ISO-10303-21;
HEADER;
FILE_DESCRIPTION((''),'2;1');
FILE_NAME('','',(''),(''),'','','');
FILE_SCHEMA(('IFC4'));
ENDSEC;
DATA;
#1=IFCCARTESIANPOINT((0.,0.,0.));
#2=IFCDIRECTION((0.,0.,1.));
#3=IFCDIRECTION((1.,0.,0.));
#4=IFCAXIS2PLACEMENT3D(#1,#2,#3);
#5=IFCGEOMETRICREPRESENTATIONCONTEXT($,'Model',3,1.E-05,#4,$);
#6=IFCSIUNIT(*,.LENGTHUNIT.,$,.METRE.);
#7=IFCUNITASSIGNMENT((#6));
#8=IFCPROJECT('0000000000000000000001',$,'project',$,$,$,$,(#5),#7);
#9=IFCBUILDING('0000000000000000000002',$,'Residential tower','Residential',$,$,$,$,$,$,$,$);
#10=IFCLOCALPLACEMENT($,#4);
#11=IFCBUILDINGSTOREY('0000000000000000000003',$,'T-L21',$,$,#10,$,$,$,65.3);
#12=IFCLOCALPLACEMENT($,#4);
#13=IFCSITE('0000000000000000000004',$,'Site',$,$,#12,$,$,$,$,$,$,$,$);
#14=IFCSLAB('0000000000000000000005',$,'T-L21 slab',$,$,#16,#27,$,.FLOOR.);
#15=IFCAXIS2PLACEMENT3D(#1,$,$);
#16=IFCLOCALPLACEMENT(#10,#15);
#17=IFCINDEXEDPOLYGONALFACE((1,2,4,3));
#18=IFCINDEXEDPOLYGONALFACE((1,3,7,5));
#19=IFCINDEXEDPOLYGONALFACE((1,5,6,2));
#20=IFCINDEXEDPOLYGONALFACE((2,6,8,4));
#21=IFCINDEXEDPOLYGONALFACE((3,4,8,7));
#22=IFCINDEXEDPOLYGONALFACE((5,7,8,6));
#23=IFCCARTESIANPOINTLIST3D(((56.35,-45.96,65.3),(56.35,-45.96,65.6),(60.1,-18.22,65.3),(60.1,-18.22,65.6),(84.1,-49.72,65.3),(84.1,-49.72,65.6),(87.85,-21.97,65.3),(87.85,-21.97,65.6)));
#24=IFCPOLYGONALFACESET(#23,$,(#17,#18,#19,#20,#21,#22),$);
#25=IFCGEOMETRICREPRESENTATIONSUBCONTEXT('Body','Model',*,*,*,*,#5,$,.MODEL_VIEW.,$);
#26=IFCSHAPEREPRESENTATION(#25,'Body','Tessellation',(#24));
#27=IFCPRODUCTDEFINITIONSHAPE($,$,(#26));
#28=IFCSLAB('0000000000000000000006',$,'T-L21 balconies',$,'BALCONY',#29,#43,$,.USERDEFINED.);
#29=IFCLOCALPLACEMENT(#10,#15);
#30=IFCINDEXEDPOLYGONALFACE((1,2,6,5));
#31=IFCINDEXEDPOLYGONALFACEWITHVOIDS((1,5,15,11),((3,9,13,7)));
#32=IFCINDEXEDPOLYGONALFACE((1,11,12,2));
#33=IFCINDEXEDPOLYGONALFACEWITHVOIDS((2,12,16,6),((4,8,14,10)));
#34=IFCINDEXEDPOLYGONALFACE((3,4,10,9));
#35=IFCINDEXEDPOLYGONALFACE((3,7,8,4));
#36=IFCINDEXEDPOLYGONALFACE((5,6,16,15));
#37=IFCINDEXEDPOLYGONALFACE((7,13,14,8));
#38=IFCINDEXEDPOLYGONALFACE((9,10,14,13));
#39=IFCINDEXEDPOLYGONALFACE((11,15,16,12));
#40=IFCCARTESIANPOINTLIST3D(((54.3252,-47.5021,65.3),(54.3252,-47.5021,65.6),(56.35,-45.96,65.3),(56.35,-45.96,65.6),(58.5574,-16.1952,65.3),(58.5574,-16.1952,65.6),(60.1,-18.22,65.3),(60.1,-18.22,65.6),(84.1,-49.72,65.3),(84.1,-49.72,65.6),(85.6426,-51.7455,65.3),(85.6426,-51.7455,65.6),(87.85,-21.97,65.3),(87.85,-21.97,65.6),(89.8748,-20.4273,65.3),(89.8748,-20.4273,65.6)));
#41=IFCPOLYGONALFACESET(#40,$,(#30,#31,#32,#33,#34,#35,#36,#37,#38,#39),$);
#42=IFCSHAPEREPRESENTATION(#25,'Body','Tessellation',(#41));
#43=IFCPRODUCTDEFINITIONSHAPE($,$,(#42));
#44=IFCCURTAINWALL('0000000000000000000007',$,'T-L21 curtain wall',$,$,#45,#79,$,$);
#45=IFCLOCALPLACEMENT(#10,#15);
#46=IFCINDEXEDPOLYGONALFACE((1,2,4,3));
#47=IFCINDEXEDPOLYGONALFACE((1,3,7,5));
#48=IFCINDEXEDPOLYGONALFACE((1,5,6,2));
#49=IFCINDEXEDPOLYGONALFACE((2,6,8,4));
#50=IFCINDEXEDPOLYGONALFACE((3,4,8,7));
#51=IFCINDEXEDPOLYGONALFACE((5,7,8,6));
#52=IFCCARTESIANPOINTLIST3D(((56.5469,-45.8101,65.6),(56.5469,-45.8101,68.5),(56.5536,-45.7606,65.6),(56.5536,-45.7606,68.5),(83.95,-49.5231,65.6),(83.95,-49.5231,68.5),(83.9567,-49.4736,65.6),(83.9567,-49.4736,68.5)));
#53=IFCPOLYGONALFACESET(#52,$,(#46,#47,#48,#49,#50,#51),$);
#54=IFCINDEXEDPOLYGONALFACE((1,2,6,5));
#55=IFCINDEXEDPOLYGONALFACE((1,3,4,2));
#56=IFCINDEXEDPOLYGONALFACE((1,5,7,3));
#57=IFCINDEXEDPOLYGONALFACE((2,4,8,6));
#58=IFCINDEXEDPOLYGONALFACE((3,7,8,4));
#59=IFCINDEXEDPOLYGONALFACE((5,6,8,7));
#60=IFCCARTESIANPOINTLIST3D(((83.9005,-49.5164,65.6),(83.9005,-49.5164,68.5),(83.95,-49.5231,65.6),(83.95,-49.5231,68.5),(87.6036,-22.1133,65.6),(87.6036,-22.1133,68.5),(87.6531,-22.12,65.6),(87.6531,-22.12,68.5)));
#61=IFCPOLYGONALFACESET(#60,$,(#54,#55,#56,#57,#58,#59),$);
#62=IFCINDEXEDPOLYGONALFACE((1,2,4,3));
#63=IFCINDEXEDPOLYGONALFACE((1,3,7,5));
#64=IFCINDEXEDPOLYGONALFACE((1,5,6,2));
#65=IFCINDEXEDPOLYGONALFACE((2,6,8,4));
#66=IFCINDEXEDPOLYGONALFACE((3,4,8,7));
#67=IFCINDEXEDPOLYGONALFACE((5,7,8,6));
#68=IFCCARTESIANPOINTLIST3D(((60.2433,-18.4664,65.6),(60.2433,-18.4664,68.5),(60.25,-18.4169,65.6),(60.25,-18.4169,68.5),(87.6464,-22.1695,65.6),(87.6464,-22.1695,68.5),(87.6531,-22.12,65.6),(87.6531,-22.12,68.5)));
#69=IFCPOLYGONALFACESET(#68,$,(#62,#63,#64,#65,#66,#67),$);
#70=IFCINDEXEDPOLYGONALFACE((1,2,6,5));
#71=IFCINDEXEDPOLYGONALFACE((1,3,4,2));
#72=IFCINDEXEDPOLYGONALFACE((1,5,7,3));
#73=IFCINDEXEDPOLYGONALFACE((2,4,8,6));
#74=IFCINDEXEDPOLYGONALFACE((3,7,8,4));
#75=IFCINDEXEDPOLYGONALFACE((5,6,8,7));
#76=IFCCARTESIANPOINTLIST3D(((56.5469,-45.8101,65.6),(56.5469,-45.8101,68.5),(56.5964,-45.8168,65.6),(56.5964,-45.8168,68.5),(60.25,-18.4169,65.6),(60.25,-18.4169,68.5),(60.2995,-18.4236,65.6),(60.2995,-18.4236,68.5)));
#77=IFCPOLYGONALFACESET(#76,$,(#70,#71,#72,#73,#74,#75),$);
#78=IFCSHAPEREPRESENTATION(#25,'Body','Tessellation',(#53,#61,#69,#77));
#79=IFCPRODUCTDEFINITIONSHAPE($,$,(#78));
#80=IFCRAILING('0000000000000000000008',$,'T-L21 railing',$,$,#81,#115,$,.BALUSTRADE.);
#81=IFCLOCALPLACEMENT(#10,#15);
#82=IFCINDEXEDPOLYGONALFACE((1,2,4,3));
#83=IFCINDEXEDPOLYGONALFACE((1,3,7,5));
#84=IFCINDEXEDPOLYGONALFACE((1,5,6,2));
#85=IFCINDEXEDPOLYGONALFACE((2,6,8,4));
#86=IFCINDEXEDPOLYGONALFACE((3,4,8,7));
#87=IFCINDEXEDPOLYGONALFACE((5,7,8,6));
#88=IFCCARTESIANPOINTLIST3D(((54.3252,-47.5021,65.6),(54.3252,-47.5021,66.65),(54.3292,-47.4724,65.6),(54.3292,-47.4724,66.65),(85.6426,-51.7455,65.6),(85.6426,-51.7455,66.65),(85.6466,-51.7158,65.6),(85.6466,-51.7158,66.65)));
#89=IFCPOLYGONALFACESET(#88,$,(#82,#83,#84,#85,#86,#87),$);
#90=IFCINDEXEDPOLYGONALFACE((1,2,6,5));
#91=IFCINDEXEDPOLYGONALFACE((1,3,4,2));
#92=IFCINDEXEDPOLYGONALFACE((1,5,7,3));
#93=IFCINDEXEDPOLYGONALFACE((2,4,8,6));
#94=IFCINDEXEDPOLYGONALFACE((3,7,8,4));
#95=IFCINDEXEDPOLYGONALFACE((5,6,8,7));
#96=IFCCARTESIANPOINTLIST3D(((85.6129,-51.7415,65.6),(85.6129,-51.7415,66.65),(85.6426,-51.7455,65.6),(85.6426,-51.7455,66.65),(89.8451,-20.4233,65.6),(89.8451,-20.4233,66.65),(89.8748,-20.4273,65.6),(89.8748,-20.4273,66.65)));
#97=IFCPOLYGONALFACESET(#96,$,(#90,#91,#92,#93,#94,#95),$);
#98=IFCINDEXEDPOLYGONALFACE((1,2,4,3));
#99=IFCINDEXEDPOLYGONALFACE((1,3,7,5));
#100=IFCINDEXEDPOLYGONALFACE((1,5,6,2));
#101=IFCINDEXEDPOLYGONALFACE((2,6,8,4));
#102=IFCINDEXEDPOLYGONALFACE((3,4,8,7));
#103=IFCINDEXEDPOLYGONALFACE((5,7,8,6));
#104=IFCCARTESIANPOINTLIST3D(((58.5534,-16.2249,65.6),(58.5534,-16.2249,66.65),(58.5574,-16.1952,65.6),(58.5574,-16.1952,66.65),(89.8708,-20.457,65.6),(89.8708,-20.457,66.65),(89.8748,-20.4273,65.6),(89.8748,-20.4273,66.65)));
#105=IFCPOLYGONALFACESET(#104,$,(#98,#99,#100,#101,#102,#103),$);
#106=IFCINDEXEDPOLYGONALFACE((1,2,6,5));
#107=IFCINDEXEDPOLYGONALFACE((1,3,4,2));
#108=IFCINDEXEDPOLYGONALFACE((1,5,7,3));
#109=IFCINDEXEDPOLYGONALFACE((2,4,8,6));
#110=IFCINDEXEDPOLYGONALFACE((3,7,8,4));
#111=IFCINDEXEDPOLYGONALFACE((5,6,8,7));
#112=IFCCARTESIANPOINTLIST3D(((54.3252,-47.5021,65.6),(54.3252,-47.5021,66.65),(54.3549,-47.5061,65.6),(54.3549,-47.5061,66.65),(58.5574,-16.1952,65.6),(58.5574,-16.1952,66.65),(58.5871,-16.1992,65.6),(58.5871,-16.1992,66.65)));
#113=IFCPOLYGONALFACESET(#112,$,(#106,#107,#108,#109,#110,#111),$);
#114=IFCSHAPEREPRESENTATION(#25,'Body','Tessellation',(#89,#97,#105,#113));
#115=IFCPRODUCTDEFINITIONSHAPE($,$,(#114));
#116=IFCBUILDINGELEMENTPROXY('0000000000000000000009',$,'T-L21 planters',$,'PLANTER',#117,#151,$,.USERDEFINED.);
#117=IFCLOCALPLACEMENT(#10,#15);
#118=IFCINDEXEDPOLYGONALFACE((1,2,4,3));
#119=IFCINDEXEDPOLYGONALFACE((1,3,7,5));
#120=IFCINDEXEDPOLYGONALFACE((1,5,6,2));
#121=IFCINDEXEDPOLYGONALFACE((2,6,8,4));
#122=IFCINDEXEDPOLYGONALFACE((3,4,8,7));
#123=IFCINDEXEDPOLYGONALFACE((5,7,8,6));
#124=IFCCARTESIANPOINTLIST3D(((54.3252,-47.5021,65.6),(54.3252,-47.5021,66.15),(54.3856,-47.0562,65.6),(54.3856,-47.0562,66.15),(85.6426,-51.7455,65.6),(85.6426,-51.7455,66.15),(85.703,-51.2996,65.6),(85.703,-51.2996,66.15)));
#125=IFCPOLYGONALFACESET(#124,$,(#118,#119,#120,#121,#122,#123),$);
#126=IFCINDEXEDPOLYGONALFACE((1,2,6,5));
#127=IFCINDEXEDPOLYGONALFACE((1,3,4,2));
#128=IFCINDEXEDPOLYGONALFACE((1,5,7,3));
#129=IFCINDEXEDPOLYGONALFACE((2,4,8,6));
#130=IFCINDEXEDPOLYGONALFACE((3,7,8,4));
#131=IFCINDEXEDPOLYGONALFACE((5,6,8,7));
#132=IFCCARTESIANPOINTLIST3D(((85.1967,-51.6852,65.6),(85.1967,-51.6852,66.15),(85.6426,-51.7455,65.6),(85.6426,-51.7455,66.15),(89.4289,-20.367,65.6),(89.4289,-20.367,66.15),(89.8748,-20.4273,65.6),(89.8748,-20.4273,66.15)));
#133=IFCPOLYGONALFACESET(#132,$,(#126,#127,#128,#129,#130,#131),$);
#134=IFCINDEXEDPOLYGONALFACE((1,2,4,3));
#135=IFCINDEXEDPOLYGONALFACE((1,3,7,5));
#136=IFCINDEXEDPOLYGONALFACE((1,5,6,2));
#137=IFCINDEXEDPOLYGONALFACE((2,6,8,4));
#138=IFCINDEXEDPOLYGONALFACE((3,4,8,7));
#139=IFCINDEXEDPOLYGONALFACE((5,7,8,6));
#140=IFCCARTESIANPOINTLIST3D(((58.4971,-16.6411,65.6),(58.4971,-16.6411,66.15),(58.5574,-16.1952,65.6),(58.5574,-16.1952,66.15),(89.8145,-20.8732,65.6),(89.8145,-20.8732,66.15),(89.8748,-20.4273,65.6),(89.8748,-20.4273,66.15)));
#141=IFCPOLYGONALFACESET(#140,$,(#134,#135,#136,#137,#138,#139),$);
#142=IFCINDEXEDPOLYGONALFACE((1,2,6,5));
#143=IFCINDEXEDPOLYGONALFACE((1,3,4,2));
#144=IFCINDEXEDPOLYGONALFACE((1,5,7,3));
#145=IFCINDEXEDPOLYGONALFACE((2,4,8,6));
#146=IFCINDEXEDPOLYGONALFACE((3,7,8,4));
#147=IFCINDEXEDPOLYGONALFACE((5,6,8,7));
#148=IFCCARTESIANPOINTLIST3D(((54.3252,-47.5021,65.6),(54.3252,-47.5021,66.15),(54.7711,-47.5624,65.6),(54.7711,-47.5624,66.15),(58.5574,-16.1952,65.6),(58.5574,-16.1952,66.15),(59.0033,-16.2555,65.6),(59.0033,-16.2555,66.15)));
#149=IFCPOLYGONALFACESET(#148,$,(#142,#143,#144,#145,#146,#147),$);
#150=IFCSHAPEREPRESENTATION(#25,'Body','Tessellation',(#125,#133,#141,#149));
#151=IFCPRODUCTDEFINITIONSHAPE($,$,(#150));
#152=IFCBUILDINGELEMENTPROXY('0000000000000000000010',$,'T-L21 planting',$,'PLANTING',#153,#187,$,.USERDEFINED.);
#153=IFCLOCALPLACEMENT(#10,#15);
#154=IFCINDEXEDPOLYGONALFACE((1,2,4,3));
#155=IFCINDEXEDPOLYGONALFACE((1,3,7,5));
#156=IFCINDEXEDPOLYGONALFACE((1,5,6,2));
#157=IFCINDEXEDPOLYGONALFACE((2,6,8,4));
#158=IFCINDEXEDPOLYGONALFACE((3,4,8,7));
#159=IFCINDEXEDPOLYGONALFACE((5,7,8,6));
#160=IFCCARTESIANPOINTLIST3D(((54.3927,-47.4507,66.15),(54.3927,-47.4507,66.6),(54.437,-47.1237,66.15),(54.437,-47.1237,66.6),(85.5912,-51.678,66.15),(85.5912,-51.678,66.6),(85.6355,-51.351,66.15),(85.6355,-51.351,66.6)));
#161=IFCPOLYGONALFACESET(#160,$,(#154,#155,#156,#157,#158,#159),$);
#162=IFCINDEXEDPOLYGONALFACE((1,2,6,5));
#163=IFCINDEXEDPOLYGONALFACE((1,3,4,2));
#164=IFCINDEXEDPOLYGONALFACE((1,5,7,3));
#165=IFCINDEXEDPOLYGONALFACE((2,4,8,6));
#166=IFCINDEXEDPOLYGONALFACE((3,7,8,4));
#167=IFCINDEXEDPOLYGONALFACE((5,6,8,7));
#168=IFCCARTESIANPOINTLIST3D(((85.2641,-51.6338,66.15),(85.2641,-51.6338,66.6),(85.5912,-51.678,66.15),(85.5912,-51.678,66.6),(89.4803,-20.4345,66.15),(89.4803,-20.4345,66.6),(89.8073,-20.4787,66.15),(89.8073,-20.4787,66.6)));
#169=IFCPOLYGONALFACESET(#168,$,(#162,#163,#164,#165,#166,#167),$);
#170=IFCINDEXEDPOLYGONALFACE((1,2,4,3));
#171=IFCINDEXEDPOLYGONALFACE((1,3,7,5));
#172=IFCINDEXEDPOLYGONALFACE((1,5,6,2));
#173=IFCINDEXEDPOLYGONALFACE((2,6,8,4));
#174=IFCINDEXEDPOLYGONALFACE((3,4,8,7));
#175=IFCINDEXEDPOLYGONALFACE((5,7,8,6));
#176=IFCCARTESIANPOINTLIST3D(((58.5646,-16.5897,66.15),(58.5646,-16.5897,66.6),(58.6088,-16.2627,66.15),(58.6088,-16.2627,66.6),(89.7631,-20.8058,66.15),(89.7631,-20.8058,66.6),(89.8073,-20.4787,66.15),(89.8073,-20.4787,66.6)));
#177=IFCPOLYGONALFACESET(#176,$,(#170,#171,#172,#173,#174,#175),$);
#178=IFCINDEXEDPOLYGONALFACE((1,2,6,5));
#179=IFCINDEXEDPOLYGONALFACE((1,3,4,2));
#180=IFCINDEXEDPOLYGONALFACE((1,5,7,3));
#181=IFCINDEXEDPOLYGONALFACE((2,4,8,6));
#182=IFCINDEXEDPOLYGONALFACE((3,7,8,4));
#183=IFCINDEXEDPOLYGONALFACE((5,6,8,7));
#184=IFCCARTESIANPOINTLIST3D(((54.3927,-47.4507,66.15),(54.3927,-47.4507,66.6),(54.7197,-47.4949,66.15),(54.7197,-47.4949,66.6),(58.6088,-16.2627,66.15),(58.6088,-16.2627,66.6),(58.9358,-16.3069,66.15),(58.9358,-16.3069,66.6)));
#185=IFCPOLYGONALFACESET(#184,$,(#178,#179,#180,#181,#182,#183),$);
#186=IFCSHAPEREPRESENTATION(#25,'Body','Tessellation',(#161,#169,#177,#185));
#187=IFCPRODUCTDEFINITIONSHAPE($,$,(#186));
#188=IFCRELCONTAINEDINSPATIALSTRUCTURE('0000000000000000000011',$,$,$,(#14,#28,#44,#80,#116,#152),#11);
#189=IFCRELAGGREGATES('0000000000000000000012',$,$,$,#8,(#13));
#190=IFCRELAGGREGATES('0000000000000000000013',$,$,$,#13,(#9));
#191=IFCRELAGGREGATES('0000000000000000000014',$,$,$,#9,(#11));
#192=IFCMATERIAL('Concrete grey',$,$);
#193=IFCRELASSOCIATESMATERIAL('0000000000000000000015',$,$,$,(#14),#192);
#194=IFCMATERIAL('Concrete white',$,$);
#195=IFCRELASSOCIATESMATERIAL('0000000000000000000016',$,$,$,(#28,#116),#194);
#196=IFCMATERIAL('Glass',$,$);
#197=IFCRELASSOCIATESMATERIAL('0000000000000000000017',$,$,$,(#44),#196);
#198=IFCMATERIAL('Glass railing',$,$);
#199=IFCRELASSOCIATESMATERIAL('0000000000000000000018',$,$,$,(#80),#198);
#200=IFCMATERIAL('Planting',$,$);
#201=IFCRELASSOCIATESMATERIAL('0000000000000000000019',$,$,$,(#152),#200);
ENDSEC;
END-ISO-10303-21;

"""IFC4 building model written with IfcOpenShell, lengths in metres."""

from ifc_helpers import new_model, si_unit, frame, origin_with_axes, place, context, subcontext, project, spatial, polyline, outline, extrude, material, element, save


model = new_model("IFC4")

# Units and contexts
model_context = context("Model", 3, precision=1e-05, world=origin_with_axes())
body_context = subcontext(model_context, "Body", "Model", "MODEL_VIEW")
ifc_project = project(units=[si_unit("LENGTHUNIT", "METRE")], contexts=[model_context])

# Site, building, storey
site_placement = place(None, origin_with_axes())
site = spatial("IfcSite", under=ifc_project, at=site_placement, Name="Site")
building = spatial("IfcBuilding", under=site, Name="Residential tower", Description="Residential")
storey_placement = place(None, origin_with_axes())
storey = spatial("IfcBuildingStorey", under=building, at=storey_placement, Name="T-L21", Elevation=65.3)

# Slabs
ifc_material_1 = material(Name="Concrete grey")
slab_1_placement = place(storey_placement, origin_with_axes())
element("IfcSlab", 1, at=slab_1_placement, inside=storey, material=ifc_material_1, Name="T-L21 slab", PredefinedType="FLOOR", context=body_context, shape_type="SweptSolid", body=[
    extrude(outline(polyline([(56.35, -45.96), (84.1, -49.72), (87.85, -21.97), (60.1, -18.22), (56.35, -45.96)])), frame((0.0, 0.0, 65.3), z_axis=(0.0, 0.0, 1.0), x_axis=(1.0, 0.0, 0.0)), (0.0, 0.0, 1.0), 0.3),
])
ifc_material_2 = material(Name="Concrete white")
slab_2_placement = place(storey_placement, origin_with_axes())
element("IfcSlab", 2, at=slab_2_placement, inside=storey, material=ifc_material_2, Name="T-L21 balconies", ObjectType="BALCONY", PredefinedType="USERDEFINED", context=body_context, shape_type="SweptSolid", body=[
    extrude(outline(polyline([(54.3252, -47.5021), (85.6426, -51.7455), (89.8748, -20.4273), (58.5574, -16.1952), (54.3252, -47.5021)]), holes=[polyline([(56.35, -45.96), (84.1, -49.72), (87.85, -21.97), (60.1, -18.22), (56.35, -45.96)])]), frame((0.0, 0.0, 65.3), z_axis=(0.0, 0.0, 1.0), x_axis=(1.0, 0.0, 0.0)), (0.0, 0.0, 1.0), 0.3),
])

# Curtain wall
ifc_material_3 = material(Name="Glass")
curtain_wall_placement = place(storey_placement, origin_with_axes())
element("IfcCurtainWall", 3, at=curtain_wall_placement, inside=storey, material=ifc_material_3, Name="T-L21 curtain wall", context=body_context, shape_type="SweptSolid", body=[
    extrude(outline(polyline([(56.5469, -45.8101), (83.95, -49.5231), (83.9567, -49.4736), (56.5536, -45.7606), (56.5469, -45.8101)])), frame((0.0, 0.0, 65.6), z_axis=(0.0, 0.0, 1.0), x_axis=(1.0, 0.0, 0.0)), (0.0, 0.0, 1.0), 2.9),
    extrude(outline(polyline([(83.95, -49.5231), (87.6531, -22.12), (87.6036, -22.1133), (83.9005, -49.5164), (83.95, -49.5231)])), frame((0.0, 0.0, 65.6), z_axis=(0.0, 0.0, 1.0), x_axis=(1.0, 0.0, 0.0)), (0.0, 0.0, 1.0), 2.9),
    extrude(outline(polyline([(87.6531, -22.12), (60.25, -18.4169), (60.2433, -18.4664), (87.6464, -22.1695), (87.6531, -22.12)])), frame((0.0, 0.0, 65.6), z_axis=(0.0, 0.0, 1.0), x_axis=(1.0, 0.0, 0.0)), (0.0, 0.0, 1.0), 2.9),
    extrude(outline(polyline([(60.25, -18.4169), (56.5469, -45.8101), (56.5964, -45.8168), (60.2995, -18.4236), (60.25, -18.4169)])), frame((0.0, 0.0, 65.6), z_axis=(0.0, 0.0, 1.0), x_axis=(1.0, 0.0, 0.0)), (0.0, 0.0, 1.0), 2.9),
])

# Railing
ifc_material_4 = material(Name="Glass railing")
railing_placement = place(storey_placement, origin_with_axes())
element("IfcRailing", 4, at=railing_placement, inside=storey, material=ifc_material_4, Name="T-L21 railing", PredefinedType="BALUSTRADE", context=body_context, shape_type="SweptSolid", body=[
    extrude(outline(polyline([(54.3252, -47.5021), (85.6426, -51.7455), (85.6466, -51.7158), (54.3292, -47.4724), (54.3252, -47.5021)])), frame((0.0, 0.0, 65.6), z_axis=(0.0, 0.0, 1.0), x_axis=(1.0, 0.0, 0.0)), (0.0, 0.0, 1.0), 1.05),
    extrude(outline(polyline([(85.6426, -51.7455), (89.8748, -20.4273), (89.8451, -20.4233), (85.6129, -51.7415), (85.6426, -51.7455)])), frame((0.0, 0.0, 65.6), z_axis=(0.0, 0.0, 1.0), x_axis=(1.0, 0.0, 0.0)), (0.0, 0.0, 1.0), 1.05),
    extrude(outline(polyline([(89.8748, -20.4273), (58.5574, -16.1952), (58.5534, -16.2249), (89.8708, -20.457), (89.8748, -20.4273)])), frame((0.0, 0.0, 65.6), z_axis=(0.0, 0.0, 1.0), x_axis=(1.0, 0.0, 0.0)), (0.0, 0.0, 1.0), 1.05),
    extrude(outline(polyline([(58.5574, -16.1952), (54.3252, -47.5021), (54.3549, -47.5061), (58.5871, -16.1992), (58.5574, -16.1952)])), frame((0.0, 0.0, 65.6), z_axis=(0.0, 0.0, 1.0), x_axis=(1.0, 0.0, 0.0)), (0.0, 0.0, 1.0), 1.05),
])

# Building element proxies
proxy_1_placement = place(storey_placement, origin_with_axes())
element("IfcBuildingElementProxy", 5, at=proxy_1_placement, inside=storey, material=ifc_material_2, Name="T-L21 planters", ObjectType="PLANTER", PredefinedType="USERDEFINED", context=body_context, shape_type="SweptSolid", body=[
    extrude(outline(polyline([(54.3252, -47.5021), (85.6426, -51.7455), (85.703, -51.2996), (54.3856, -47.0562), (54.3252, -47.5021)])), frame((0.0, 0.0, 65.6), z_axis=(0.0, 0.0, 1.0), x_axis=(1.0, 0.0, 0.0)), (0.0, 0.0, 1.0), 0.55),
    extrude(outline(polyline([(85.6426, -51.7455), (89.8748, -20.4273), (89.4289, -20.367), (85.1967, -51.6852), (85.6426, -51.7455)])), frame((0.0, 0.0, 65.6), z_axis=(0.0, 0.0, 1.0), x_axis=(1.0, 0.0, 0.0)), (0.0, 0.0, 1.0), 0.55),
    extrude(outline(polyline([(89.8748, -20.4273), (58.5574, -16.1952), (58.4971, -16.6411), (89.8145, -20.8732), (89.8748, -20.4273)])), frame((0.0, 0.0, 65.6), z_axis=(0.0, 0.0, 1.0), x_axis=(1.0, 0.0, 0.0)), (0.0, 0.0, 1.0), 0.55),
    extrude(outline(polyline([(58.5574, -16.1952), (54.3252, -47.5021), (54.7711, -47.5624), (59.0033, -16.2555), (58.5574, -16.1952)])), frame((0.0, 0.0, 65.6), z_axis=(0.0, 0.0, 1.0), x_axis=(1.0, 0.0, 0.0)), (0.0, 0.0, 1.0), 0.55),
])
ifc_material_5 = material(Name="Planting")
proxy_2_placement = place(storey_placement, origin_with_axes())
element("IfcBuildingElementProxy", 6, at=proxy_2_placement, inside=storey, material=ifc_material_5, Name="T-L21 planting", ObjectType="PLANTING", PredefinedType="USERDEFINED", context=body_context, shape_type="SweptSolid", body=[
    extrude(outline(polyline([(54.3927, -47.4507), (85.5912, -51.678), (85.6355, -51.351), (54.437, -47.1237), (54.3927, -47.4507)])), frame((0.0, 0.0, 66.15), z_axis=(0.0, 0.0, 1.0), x_axis=(1.0, 0.0, 0.0)), (0.0, 0.0, 1.0), 0.45),
    extrude(outline(polyline([(85.5912, -51.678), (89.8073, -20.4787), (89.4803, -20.4345), (85.2641, -51.6338), (85.5912, -51.678)])), frame((0.0, 0.0, 66.15), z_axis=(0.0, 0.0, 1.0), x_axis=(1.0, 0.0, 0.0)), (0.0, 0.0, 1.0), 0.45),
    extrude(outline(polyline([(89.8073, -20.4787), (58.6088, -16.2627), (58.5646, -16.5897), (89.7631, -20.8058), (89.8073, -20.4787)])), frame((0.0, 0.0, 66.15), z_axis=(0.0, 0.0, 1.0), x_axis=(1.0, 0.0, 0.0)), (0.0, 0.0, 1.0), 0.45),
    extrude(outline(polyline([(58.6088, -16.2627), (54.3927, -47.4507), (54.7197, -47.4949), (58.9358, -16.3069), (58.6088, -16.2627)])), frame((0.0, 0.0, 66.15), z_axis=(0.0, 0.0, 1.0), x_axis=(1.0, 0.0, 0.0)), (0.0, 0.0, 1.0), 0.45),
])

save(model, "model.ifc")
